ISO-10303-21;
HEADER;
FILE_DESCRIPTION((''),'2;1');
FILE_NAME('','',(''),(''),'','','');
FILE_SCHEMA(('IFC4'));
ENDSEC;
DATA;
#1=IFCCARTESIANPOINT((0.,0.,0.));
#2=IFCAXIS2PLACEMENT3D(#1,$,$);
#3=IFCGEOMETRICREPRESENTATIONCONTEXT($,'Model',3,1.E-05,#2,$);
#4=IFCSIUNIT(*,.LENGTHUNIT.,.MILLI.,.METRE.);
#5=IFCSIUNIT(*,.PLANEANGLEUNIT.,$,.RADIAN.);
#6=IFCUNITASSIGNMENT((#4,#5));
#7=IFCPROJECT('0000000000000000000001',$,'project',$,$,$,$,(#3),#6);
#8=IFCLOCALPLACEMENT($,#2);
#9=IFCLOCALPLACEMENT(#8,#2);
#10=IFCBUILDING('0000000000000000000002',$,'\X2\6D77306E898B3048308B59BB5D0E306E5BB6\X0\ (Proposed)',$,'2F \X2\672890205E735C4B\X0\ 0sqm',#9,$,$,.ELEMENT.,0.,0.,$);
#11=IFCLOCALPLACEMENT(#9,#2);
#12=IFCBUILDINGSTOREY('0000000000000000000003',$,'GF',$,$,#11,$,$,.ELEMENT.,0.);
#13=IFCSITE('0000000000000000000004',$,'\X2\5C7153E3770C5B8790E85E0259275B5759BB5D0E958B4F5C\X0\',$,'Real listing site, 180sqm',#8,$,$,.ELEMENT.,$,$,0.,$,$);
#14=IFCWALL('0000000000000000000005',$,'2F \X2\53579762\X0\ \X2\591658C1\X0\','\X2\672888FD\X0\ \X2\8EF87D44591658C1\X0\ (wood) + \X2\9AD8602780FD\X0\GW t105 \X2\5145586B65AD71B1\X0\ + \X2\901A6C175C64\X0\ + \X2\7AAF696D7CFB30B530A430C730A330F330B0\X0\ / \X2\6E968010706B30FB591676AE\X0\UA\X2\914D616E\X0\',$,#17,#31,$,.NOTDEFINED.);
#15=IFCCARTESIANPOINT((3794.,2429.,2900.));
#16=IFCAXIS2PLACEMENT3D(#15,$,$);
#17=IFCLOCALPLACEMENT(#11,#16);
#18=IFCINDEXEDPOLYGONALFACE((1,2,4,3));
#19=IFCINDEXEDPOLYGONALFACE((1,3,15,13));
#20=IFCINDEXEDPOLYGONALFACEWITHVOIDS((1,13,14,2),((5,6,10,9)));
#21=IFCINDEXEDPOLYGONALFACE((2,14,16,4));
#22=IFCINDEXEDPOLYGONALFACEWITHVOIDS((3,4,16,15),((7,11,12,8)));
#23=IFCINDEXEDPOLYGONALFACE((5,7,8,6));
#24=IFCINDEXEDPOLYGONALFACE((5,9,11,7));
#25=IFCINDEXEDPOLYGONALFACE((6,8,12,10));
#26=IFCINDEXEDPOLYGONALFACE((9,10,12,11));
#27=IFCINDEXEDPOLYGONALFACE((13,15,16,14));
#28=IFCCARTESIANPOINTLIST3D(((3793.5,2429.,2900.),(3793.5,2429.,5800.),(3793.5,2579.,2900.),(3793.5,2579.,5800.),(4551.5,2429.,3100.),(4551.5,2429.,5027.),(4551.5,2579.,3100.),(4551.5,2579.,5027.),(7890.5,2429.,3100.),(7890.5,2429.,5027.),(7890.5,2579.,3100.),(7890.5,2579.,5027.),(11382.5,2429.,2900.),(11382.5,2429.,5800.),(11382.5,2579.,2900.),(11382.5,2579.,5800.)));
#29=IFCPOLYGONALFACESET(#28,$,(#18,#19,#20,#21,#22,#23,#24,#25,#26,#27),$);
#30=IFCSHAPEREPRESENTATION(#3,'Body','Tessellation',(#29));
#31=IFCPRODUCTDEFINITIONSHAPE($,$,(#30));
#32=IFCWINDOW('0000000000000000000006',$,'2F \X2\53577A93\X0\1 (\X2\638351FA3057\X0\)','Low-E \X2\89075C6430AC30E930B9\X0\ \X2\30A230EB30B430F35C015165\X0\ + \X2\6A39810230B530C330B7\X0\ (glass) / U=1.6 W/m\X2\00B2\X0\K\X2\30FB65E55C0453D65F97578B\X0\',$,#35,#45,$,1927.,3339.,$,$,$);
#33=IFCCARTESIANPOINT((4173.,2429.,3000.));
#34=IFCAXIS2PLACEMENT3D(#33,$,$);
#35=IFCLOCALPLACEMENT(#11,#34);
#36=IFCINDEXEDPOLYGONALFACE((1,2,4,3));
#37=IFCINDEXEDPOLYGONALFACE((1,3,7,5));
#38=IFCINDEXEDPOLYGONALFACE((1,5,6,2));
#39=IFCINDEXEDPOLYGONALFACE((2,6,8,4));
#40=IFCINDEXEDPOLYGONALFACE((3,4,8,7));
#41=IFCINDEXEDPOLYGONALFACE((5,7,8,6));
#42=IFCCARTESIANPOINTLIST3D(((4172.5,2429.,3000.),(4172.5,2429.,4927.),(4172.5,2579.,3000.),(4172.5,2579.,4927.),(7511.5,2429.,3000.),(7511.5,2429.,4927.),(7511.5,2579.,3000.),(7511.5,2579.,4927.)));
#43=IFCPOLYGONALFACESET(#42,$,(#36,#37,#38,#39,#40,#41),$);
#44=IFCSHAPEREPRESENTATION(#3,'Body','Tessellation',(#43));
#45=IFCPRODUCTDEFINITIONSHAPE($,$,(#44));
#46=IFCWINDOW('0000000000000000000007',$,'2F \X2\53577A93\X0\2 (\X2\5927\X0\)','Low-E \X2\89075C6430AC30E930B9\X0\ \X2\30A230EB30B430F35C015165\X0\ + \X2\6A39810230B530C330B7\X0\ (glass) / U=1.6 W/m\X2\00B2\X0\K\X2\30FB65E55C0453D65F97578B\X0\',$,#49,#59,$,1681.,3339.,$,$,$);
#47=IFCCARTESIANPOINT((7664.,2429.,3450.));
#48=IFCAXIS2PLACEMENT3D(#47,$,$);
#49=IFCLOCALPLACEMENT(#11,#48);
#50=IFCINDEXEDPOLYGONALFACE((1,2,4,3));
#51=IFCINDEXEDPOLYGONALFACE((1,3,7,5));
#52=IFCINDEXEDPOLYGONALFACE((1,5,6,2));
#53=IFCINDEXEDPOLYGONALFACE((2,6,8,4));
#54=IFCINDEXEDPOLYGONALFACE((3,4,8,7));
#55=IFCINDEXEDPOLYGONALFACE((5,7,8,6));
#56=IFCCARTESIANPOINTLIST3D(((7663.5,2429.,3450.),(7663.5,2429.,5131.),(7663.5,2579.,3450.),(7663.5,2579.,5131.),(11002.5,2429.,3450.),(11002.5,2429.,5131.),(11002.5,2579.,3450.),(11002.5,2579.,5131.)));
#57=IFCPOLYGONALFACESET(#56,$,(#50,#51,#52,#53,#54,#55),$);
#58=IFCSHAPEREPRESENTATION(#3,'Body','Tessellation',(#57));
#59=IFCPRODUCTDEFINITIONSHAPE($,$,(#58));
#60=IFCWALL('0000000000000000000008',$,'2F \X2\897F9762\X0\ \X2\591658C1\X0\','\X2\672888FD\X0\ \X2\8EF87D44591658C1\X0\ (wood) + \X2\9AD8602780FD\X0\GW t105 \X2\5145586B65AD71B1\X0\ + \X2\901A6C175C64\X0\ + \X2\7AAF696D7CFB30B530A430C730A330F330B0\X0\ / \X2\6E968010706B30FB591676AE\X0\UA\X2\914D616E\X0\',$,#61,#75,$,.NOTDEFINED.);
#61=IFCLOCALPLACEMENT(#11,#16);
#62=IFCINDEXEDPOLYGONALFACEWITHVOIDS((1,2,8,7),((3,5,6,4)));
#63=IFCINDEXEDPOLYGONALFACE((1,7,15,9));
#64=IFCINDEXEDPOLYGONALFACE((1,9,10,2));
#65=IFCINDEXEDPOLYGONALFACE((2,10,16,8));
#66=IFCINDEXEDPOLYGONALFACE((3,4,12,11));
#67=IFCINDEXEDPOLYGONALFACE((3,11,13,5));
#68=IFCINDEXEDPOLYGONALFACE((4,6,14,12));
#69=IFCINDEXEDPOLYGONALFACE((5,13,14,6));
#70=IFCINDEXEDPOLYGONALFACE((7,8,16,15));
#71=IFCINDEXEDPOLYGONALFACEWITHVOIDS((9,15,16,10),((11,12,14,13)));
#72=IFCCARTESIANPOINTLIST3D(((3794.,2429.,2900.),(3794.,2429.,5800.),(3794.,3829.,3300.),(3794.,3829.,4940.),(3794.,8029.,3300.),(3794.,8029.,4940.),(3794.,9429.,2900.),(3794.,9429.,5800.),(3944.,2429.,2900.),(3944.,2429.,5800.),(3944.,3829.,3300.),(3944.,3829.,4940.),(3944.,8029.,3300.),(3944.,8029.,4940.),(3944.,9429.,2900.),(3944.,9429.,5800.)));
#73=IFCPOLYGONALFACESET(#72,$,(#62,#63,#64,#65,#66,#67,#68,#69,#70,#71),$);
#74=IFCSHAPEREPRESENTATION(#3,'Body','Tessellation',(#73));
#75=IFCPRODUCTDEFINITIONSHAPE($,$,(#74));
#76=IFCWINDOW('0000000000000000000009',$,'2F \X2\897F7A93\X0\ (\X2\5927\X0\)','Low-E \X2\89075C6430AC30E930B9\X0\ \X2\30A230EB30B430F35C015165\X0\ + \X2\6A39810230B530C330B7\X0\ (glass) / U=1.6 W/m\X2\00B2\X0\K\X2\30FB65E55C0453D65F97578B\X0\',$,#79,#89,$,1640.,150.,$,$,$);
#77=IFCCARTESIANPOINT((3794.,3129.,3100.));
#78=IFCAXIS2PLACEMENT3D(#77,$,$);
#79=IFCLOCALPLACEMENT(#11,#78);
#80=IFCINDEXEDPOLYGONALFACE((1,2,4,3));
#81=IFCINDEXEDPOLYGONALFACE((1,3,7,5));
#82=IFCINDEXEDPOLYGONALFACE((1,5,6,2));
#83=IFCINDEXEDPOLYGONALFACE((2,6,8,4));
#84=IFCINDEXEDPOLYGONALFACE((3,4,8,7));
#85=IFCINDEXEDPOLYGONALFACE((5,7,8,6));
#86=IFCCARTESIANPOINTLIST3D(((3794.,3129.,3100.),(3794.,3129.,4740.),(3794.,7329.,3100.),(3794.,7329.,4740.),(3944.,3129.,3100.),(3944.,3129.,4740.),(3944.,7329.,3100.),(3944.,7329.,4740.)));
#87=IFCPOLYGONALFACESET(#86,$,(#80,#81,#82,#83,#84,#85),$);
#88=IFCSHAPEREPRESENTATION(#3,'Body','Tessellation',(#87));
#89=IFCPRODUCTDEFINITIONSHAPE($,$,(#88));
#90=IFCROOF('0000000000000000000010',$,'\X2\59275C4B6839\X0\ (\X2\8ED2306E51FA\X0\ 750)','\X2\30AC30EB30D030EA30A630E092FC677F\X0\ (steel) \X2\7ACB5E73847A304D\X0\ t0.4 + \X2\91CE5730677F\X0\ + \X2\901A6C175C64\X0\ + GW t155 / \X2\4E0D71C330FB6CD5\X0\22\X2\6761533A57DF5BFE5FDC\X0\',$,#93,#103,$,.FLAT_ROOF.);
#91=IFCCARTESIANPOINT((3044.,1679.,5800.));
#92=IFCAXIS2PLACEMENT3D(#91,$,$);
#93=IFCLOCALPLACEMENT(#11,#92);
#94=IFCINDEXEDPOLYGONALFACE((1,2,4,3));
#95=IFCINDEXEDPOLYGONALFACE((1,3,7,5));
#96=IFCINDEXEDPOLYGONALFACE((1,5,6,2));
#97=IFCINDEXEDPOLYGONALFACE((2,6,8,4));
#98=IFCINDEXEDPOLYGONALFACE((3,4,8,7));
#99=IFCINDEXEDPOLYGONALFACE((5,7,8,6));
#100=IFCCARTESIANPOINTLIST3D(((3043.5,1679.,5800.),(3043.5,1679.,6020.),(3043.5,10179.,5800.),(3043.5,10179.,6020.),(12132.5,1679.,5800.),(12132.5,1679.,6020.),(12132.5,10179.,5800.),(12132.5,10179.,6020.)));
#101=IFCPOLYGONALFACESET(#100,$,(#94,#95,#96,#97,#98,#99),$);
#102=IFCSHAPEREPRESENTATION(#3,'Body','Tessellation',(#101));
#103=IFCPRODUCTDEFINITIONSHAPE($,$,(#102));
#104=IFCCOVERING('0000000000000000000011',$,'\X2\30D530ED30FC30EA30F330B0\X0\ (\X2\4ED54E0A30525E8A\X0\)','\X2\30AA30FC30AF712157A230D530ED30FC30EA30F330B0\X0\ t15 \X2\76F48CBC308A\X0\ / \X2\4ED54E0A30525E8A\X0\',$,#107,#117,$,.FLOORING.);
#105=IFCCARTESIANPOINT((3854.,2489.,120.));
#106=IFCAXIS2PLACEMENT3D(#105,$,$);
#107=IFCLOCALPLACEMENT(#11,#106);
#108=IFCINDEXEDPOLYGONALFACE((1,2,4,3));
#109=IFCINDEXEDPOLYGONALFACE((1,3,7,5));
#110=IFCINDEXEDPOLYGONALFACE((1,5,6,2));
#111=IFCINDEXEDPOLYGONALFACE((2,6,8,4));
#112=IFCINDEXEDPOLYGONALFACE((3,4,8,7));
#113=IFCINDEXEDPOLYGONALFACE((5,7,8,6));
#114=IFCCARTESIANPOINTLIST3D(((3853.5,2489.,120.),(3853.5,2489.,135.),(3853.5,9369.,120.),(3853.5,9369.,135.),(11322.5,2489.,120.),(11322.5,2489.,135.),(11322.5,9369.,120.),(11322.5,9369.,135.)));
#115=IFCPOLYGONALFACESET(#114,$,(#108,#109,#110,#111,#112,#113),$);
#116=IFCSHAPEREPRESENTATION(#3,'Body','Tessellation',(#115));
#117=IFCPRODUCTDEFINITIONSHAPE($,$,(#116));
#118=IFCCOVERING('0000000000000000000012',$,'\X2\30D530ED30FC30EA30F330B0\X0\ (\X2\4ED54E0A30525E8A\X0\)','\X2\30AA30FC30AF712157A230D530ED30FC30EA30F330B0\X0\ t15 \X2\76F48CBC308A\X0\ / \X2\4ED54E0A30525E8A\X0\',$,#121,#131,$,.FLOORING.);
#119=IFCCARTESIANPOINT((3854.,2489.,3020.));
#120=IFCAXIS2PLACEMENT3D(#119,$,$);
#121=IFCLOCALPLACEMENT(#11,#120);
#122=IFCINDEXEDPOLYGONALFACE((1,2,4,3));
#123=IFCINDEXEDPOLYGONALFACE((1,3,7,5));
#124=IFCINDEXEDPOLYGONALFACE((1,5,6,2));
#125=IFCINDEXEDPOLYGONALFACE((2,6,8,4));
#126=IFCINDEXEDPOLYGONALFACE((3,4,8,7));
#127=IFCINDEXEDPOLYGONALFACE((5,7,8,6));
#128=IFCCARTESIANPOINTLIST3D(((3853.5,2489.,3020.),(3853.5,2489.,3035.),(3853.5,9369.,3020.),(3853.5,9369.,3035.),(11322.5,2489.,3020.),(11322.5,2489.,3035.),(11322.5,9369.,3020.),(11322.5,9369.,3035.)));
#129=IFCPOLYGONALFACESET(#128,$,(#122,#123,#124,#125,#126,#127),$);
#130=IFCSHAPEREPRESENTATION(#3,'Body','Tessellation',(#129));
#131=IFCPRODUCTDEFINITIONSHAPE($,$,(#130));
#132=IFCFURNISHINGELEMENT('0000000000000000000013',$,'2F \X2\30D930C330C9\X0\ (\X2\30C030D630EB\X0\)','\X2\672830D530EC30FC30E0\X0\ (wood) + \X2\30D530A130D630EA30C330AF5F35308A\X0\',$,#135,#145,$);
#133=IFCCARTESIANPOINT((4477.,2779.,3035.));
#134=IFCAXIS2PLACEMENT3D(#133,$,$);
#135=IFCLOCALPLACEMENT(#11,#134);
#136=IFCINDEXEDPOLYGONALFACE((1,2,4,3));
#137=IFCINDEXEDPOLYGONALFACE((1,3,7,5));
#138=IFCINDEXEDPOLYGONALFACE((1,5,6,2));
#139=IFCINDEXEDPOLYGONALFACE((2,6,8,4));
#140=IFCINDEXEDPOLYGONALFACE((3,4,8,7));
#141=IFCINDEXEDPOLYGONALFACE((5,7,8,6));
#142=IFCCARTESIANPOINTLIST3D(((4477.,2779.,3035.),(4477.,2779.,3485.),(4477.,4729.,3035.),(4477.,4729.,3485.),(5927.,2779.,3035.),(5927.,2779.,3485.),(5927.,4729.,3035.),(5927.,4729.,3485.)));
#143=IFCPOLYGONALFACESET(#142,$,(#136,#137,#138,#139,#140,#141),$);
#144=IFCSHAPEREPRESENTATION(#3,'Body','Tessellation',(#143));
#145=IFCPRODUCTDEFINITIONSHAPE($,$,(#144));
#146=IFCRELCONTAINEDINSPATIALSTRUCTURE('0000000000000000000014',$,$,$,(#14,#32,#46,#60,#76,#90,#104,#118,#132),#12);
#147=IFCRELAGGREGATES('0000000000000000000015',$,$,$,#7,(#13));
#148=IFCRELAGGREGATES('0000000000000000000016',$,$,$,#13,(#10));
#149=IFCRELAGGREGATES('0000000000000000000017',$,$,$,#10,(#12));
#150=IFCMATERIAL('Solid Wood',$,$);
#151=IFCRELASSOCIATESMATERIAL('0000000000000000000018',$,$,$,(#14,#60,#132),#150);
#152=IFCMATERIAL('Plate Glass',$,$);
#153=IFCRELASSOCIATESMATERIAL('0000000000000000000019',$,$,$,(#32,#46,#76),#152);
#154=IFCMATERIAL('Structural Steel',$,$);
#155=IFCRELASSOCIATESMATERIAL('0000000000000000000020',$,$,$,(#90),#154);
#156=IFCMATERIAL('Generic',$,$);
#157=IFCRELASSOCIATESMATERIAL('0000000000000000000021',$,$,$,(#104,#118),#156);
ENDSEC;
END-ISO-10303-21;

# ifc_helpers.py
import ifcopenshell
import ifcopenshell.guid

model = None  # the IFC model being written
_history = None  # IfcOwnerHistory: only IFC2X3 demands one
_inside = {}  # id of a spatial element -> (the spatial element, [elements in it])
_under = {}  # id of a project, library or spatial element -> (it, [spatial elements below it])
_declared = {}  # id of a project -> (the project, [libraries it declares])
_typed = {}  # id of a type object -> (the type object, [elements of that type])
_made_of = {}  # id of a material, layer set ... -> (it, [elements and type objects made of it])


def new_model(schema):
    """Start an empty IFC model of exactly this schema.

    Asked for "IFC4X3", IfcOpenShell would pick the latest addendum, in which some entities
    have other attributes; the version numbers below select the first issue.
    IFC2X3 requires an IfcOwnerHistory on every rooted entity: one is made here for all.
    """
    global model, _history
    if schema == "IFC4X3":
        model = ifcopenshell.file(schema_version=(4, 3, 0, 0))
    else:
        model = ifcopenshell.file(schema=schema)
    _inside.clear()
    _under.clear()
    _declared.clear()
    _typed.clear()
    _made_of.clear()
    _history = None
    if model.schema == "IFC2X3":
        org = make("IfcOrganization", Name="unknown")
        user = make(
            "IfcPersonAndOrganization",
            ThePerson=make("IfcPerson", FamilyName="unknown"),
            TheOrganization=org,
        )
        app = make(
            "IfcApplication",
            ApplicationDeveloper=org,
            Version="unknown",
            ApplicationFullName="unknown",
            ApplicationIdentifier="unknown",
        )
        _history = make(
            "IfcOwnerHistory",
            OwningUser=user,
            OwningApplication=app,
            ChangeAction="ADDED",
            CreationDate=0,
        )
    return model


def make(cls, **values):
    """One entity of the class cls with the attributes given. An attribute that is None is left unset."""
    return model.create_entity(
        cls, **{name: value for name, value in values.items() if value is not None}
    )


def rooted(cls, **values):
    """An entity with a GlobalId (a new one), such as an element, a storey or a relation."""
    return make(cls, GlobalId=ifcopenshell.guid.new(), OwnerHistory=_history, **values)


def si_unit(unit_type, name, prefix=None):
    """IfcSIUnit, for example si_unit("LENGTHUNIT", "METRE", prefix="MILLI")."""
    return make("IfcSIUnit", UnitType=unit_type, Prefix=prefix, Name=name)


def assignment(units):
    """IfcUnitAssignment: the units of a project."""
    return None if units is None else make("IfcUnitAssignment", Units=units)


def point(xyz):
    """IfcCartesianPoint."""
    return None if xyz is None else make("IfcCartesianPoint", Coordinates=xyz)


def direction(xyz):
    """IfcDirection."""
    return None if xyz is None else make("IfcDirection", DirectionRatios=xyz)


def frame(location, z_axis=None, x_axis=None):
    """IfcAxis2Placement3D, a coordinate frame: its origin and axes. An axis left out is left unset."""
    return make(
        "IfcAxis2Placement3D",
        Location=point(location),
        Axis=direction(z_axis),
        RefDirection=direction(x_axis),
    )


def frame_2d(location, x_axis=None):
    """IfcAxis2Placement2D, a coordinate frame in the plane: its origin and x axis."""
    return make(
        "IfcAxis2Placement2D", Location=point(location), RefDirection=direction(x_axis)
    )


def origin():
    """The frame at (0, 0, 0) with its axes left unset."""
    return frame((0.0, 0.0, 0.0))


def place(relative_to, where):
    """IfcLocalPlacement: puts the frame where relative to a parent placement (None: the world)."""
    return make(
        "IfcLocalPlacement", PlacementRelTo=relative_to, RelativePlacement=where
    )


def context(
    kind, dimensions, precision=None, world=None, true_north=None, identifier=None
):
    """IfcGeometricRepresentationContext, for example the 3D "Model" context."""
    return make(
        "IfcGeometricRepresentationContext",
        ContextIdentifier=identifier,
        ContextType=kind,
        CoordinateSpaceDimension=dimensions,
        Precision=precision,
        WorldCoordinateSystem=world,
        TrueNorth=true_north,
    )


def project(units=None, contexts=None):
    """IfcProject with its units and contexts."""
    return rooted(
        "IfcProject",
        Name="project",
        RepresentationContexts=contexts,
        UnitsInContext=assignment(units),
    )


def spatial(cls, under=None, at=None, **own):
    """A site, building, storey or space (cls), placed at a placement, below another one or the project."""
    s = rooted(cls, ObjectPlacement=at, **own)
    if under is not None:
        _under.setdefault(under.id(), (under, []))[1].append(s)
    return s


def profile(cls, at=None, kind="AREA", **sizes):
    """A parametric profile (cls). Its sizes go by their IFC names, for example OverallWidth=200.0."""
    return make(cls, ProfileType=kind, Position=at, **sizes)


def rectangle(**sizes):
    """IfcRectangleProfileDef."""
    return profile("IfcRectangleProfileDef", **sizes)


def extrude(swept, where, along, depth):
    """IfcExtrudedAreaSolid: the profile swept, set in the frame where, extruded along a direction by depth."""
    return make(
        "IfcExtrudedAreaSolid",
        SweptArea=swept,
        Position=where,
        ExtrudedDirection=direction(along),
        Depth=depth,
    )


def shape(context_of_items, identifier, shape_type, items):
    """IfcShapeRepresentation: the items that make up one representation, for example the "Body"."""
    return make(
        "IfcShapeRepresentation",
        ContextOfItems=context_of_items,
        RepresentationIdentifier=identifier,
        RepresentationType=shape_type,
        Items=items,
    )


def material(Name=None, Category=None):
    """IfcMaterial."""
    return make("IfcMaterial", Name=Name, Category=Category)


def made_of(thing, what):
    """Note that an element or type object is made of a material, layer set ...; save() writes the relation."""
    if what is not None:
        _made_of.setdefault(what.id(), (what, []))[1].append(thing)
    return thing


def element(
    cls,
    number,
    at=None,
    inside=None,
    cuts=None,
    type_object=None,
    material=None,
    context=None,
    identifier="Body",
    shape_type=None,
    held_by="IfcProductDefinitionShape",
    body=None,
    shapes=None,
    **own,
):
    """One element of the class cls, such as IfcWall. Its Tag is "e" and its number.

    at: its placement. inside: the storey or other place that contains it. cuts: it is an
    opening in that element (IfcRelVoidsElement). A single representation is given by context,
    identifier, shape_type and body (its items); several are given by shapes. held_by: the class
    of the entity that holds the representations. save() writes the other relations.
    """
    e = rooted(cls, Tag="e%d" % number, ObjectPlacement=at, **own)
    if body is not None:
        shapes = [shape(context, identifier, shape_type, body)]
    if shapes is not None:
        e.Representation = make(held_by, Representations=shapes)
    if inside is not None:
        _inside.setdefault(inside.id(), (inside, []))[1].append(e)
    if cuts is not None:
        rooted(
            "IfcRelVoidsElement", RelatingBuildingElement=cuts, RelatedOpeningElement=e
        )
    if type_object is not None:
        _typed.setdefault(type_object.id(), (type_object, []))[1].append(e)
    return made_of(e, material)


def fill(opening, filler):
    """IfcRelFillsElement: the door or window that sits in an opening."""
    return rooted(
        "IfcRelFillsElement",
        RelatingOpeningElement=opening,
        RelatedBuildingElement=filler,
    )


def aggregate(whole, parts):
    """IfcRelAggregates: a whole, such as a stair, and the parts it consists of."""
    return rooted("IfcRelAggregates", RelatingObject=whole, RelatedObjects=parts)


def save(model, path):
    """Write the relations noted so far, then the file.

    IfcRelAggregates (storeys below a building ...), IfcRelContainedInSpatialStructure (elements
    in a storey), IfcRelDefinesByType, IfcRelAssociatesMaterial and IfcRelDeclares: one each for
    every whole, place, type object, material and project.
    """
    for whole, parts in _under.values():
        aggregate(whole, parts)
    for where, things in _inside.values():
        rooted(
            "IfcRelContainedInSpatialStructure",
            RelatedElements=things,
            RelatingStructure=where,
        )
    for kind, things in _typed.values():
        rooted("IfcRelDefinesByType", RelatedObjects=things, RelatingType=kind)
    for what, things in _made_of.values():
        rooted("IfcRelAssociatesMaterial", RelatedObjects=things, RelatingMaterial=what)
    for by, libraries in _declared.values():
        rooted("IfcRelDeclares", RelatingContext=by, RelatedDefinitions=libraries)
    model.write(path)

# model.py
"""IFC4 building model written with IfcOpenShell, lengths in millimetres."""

from ifc_helpers import new_model, si_unit, frame, frame_2d, origin, place, context, project, spatial, rectangle, extrude, material, element, fill, save


model = new_model("IFC4")

# Units and contexts
model_context = context("Model", 3, precision=1e-05, world=origin())
ifc_project = project(units=[si_unit("LENGTHUNIT", "METRE", prefix="MILLI"), si_unit("PLANEANGLEUNIT", "RADIAN")], contexts=[model_context])

# Site, building, storey
site_placement = place(None, origin())
site = spatial("IfcSite", under=ifc_project, at=site_placement, Name="山口県宇部市大字妻崎開作", ObjectType="Real listing site, 180sqm", CompositionType="ELEMENT", RefElevation=0.0)
building_placement = place(site_placement, origin())
building = spatial("IfcBuilding", under=site, at=building_placement, Name="海の見える妻崎の家 (Proposed)", ObjectType="2F 木造平屋 0sqm", CompositionType="ELEMENT", ElevationOfRefHeight=0.0, ElevationOfTerrain=0.0)
storey_placement = place(building_placement, origin())
storey = spatial("IfcBuildingStorey", under=building, at=storey_placement, Name="GF", CompositionType="ELEMENT", Elevation=0.0)

# Shared definitions
ifc_material_1 = material(Name="Solid Wood")

# Shared definitions
ifc_material_2 = material(Name="Plate Glass")

# Wall, openings, windows
wall_1_placement = place(storey_placement, frame((3794.0, 2429.0, 2900.0)))
wall_1 = element("IfcWall", 1, at=wall_1_placement, inside=storey, material=ifc_material_1, Name="2F 南面 外壁", Description="木製 軸組外壁 (wood) + 高性能GW t105 充填断熱 + 通気層 + 窯業系サイディング / 準耐火・外皮UA配慮", PredefinedType="NOTDEFINED", context=model_context, shape_type="SweptSolid", body=[
    extrude(rectangle(XDim=7589.0, YDim=150.0, at=frame_2d((3794.0, 75.0))), frame((3794.0, 2429.0, 2900.0)), (0.0, 0.0, 1.0), 2900.0),
])
opening_1_placement = place(storey_placement, frame((4173.0, 2429.0, 3000.0)))
opening_1 = element("IfcOpeningElement", 2, at=opening_1_placement, cuts=wall_1, PredefinedType="NOTDEFINED", context=model_context, shape_type="SweptSolid", body=[
    extrude(rectangle(XDim=3339.0, YDim=150.0, at=frame_2d((1669.0, 75.0))), frame((4173.0, 2429.0, 3000.0)), (0.0, 0.0, 1.0), 1927.0),
])
opening_2_placement = place(storey_placement, frame((7664.0, 2429.0, 3450.0)))
opening_2 = element("IfcOpeningElement", 3, at=opening_2_placement, cuts=wall_1, PredefinedType="NOTDEFINED", context=model_context, shape_type="SweptSolid", body=[
    extrude(rectangle(XDim=3339.0, YDim=150.0, at=frame_2d((1669.0, 75.0))), frame((7664.0, 2429.0, 3450.0)), (0.0, 0.0, 1.0), 1681.0),
])
window_1_placement = place(storey_placement, frame((4173.0, 2429.0, 3000.0)))
window_1 = element("IfcWindow", 4, at=window_1_placement, inside=storey, material=ifc_material_2, Name="2F 南窓1 (掃出し)", Description="Low-E 複層ガラス アルゴン封入 + 樹脂サッシ (glass) / U=1.6 W/m²K・日射取得型", OverallHeight=1927.0, OverallWidth=3339.0, context=model_context, shape_type="SweptSolid", body=[
    extrude(rectangle(XDim=3339.0, YDim=150.0, at=frame_2d((1669.0, 75.0))), frame((4173.0, 2429.0, 3000.0)), (0.0, 0.0, 1.0), 1927.0),
])
fill(opening_1, window_1)
window_2_placement = place(storey_placement, frame((7664.0, 2429.0, 3450.0)))
window_2 = element("IfcWindow", 5, at=window_2_placement, inside=storey, material=ifc_material_2, Name="2F 南窓2 (大)", Description="Low-E 複層ガラス アルゴン封入 + 樹脂サッシ (glass) / U=1.6 W/m²K・日射取得型", OverallHeight=1681.0, OverallWidth=3339.0, context=model_context, shape_type="SweptSolid", body=[
    extrude(rectangle(XDim=3339.0, YDim=150.0, at=frame_2d((1669.0, 75.0))), frame((7664.0, 2429.0, 3450.0)), (0.0, 0.0, 1.0), 1681.0),
])
fill(opening_2, window_2)

# Wall, opening, window
wall_2_placement = place(storey_placement, frame((3794.0, 2429.0, 2900.0)))
wall_2 = element("IfcWall", 6, at=wall_2_placement, inside=storey, material=ifc_material_1, Name="2F 西面 外壁", Description="木製 軸組外壁 (wood) + 高性能GW t105 充填断熱 + 通気層 + 窯業系サイディング / 準耐火・外皮UA配慮", PredefinedType="NOTDEFINED", context=model_context, shape_type="SweptSolid", body=[
    extrude(rectangle(XDim=150.0, YDim=7000.0, at=frame_2d((75.0, 3500.0))), frame((3794.0, 2429.0, 2900.0)), (0.0, 0.0, 1.0), 2900.0),
])
opening_3_placement = place(storey_placement, frame((3794.0, 3129.0, 3100.0)))
opening_3 = element("IfcOpeningElement", 7, at=opening_3_placement, cuts=wall_2, PredefinedType="NOTDEFINED", context=model_context, shape_type="SweptSolid", body=[
    extrude(rectangle(XDim=150.0, YDim=4200.0, at=frame_2d((75.0, 2100.0))), frame((3794.0, 3129.0, 3100.0)), (0.0, 0.0, 1.0), 1640.0),
])
window_3_placement = place(storey_placement, frame((3794.0, 3129.0, 3100.0)))
window_3 = element("IfcWindow", 8, at=window_3_placement, inside=storey, material=ifc_material_2, Name="2F 西窓 (大)", Description="Low-E 複層ガラス アルゴン封入 + 樹脂サッシ (glass) / U=1.6 W/m²K・日射取得型", OverallHeight=1640.0, OverallWidth=150.0, context=model_context, shape_type="SweptSolid", body=[
    extrude(rectangle(XDim=150.0, YDim=4200.0, at=frame_2d((75.0, 2100.0))), frame((3794.0, 3129.0, 3100.0)), (0.0, 0.0, 1.0), 1640.0),
])
fill(opening_3, window_3)

# Roof
ifc_material_3 = material(Name="Structural Steel")
roof_placement = place(storey_placement, frame((3044.0, 1679.0, 5800.0)))
element("IfcRoof", 9, at=roof_placement, inside=storey, material=ifc_material_3, Name="大屋根 (軒の出 750)", Description="ガルバリウム鋼板 (steel) 立平葺き t0.4 + 野地板 + 通気層 + GW t155 / 不燃・法22条区域対応", PredefinedType="FLAT_ROOF", context=model_context, shape_type="SweptSolid", body=[
    extrude(rectangle(XDim=9089.0, YDim=8500.0, at=frame_2d((4544.0, 4250.0))), frame((3044.0, 1679.0, 5800.0)), (0.0, 0.0, 1.0), 220.0),
])

# Coverings
ifc_material_4 = material(Name="Generic")
covering_1_placement = place(storey_placement, frame((3854.0, 2489.0, 120.0)))
element("IfcCovering", 10, at=covering_1_placement, inside=storey, material=ifc_material_4, Name="フローリング (仕上げ床)", Description="オーク無垢フローリング t15 直貼り / 仕上げ床", PredefinedType="FLOORING", context=model_context, shape_type="SweptSolid", body=[
    extrude(rectangle(XDim=7469.0, YDim=6880.0, at=frame_2d((3734.0, 3440.0))), frame((3854.0, 2489.0, 120.0)), (0.0, 0.0, 1.0), 15.0),
])
covering_2_placement = place(storey_placement, frame((3854.0, 2489.0, 3020.0)))
element("IfcCovering", 11, at=covering_2_placement, inside=storey, material=ifc_material_4, Name="フローリング (仕上げ床)", Description="オーク無垢フローリング t15 直貼り / 仕上げ床", PredefinedType="FLOORING", context=model_context, shape_type="SweptSolid", body=[
    extrude(rectangle(XDim=7469.0, YDim=6880.0, at=frame_2d((3734.0, 3440.0))), frame((3854.0, 2489.0, 3020.0)), (0.0, 0.0, 1.0), 15.0),
])

# Furnishing element
furnishing_placement = place(storey_placement, frame((4477.0, 2779.0, 3035.0)))
element("IfcFurnishingElement", 12, at=furnishing_placement, inside=storey, material=ifc_material_1, Name="2F ベッド (ダブル)", Description="木フレーム (wood) + ファブリック張り", context=model_context, shape_type="SweptSolid", body=[
    extrude(rectangle(XDim=1450.0, YDim=1950.0, at=frame_2d((725.0, 975.0))), frame((4477.0, 2779.0, 3035.0)), (0.0, 0.0, 1.0), 450.0),
])

save(model, "model.ifc")
